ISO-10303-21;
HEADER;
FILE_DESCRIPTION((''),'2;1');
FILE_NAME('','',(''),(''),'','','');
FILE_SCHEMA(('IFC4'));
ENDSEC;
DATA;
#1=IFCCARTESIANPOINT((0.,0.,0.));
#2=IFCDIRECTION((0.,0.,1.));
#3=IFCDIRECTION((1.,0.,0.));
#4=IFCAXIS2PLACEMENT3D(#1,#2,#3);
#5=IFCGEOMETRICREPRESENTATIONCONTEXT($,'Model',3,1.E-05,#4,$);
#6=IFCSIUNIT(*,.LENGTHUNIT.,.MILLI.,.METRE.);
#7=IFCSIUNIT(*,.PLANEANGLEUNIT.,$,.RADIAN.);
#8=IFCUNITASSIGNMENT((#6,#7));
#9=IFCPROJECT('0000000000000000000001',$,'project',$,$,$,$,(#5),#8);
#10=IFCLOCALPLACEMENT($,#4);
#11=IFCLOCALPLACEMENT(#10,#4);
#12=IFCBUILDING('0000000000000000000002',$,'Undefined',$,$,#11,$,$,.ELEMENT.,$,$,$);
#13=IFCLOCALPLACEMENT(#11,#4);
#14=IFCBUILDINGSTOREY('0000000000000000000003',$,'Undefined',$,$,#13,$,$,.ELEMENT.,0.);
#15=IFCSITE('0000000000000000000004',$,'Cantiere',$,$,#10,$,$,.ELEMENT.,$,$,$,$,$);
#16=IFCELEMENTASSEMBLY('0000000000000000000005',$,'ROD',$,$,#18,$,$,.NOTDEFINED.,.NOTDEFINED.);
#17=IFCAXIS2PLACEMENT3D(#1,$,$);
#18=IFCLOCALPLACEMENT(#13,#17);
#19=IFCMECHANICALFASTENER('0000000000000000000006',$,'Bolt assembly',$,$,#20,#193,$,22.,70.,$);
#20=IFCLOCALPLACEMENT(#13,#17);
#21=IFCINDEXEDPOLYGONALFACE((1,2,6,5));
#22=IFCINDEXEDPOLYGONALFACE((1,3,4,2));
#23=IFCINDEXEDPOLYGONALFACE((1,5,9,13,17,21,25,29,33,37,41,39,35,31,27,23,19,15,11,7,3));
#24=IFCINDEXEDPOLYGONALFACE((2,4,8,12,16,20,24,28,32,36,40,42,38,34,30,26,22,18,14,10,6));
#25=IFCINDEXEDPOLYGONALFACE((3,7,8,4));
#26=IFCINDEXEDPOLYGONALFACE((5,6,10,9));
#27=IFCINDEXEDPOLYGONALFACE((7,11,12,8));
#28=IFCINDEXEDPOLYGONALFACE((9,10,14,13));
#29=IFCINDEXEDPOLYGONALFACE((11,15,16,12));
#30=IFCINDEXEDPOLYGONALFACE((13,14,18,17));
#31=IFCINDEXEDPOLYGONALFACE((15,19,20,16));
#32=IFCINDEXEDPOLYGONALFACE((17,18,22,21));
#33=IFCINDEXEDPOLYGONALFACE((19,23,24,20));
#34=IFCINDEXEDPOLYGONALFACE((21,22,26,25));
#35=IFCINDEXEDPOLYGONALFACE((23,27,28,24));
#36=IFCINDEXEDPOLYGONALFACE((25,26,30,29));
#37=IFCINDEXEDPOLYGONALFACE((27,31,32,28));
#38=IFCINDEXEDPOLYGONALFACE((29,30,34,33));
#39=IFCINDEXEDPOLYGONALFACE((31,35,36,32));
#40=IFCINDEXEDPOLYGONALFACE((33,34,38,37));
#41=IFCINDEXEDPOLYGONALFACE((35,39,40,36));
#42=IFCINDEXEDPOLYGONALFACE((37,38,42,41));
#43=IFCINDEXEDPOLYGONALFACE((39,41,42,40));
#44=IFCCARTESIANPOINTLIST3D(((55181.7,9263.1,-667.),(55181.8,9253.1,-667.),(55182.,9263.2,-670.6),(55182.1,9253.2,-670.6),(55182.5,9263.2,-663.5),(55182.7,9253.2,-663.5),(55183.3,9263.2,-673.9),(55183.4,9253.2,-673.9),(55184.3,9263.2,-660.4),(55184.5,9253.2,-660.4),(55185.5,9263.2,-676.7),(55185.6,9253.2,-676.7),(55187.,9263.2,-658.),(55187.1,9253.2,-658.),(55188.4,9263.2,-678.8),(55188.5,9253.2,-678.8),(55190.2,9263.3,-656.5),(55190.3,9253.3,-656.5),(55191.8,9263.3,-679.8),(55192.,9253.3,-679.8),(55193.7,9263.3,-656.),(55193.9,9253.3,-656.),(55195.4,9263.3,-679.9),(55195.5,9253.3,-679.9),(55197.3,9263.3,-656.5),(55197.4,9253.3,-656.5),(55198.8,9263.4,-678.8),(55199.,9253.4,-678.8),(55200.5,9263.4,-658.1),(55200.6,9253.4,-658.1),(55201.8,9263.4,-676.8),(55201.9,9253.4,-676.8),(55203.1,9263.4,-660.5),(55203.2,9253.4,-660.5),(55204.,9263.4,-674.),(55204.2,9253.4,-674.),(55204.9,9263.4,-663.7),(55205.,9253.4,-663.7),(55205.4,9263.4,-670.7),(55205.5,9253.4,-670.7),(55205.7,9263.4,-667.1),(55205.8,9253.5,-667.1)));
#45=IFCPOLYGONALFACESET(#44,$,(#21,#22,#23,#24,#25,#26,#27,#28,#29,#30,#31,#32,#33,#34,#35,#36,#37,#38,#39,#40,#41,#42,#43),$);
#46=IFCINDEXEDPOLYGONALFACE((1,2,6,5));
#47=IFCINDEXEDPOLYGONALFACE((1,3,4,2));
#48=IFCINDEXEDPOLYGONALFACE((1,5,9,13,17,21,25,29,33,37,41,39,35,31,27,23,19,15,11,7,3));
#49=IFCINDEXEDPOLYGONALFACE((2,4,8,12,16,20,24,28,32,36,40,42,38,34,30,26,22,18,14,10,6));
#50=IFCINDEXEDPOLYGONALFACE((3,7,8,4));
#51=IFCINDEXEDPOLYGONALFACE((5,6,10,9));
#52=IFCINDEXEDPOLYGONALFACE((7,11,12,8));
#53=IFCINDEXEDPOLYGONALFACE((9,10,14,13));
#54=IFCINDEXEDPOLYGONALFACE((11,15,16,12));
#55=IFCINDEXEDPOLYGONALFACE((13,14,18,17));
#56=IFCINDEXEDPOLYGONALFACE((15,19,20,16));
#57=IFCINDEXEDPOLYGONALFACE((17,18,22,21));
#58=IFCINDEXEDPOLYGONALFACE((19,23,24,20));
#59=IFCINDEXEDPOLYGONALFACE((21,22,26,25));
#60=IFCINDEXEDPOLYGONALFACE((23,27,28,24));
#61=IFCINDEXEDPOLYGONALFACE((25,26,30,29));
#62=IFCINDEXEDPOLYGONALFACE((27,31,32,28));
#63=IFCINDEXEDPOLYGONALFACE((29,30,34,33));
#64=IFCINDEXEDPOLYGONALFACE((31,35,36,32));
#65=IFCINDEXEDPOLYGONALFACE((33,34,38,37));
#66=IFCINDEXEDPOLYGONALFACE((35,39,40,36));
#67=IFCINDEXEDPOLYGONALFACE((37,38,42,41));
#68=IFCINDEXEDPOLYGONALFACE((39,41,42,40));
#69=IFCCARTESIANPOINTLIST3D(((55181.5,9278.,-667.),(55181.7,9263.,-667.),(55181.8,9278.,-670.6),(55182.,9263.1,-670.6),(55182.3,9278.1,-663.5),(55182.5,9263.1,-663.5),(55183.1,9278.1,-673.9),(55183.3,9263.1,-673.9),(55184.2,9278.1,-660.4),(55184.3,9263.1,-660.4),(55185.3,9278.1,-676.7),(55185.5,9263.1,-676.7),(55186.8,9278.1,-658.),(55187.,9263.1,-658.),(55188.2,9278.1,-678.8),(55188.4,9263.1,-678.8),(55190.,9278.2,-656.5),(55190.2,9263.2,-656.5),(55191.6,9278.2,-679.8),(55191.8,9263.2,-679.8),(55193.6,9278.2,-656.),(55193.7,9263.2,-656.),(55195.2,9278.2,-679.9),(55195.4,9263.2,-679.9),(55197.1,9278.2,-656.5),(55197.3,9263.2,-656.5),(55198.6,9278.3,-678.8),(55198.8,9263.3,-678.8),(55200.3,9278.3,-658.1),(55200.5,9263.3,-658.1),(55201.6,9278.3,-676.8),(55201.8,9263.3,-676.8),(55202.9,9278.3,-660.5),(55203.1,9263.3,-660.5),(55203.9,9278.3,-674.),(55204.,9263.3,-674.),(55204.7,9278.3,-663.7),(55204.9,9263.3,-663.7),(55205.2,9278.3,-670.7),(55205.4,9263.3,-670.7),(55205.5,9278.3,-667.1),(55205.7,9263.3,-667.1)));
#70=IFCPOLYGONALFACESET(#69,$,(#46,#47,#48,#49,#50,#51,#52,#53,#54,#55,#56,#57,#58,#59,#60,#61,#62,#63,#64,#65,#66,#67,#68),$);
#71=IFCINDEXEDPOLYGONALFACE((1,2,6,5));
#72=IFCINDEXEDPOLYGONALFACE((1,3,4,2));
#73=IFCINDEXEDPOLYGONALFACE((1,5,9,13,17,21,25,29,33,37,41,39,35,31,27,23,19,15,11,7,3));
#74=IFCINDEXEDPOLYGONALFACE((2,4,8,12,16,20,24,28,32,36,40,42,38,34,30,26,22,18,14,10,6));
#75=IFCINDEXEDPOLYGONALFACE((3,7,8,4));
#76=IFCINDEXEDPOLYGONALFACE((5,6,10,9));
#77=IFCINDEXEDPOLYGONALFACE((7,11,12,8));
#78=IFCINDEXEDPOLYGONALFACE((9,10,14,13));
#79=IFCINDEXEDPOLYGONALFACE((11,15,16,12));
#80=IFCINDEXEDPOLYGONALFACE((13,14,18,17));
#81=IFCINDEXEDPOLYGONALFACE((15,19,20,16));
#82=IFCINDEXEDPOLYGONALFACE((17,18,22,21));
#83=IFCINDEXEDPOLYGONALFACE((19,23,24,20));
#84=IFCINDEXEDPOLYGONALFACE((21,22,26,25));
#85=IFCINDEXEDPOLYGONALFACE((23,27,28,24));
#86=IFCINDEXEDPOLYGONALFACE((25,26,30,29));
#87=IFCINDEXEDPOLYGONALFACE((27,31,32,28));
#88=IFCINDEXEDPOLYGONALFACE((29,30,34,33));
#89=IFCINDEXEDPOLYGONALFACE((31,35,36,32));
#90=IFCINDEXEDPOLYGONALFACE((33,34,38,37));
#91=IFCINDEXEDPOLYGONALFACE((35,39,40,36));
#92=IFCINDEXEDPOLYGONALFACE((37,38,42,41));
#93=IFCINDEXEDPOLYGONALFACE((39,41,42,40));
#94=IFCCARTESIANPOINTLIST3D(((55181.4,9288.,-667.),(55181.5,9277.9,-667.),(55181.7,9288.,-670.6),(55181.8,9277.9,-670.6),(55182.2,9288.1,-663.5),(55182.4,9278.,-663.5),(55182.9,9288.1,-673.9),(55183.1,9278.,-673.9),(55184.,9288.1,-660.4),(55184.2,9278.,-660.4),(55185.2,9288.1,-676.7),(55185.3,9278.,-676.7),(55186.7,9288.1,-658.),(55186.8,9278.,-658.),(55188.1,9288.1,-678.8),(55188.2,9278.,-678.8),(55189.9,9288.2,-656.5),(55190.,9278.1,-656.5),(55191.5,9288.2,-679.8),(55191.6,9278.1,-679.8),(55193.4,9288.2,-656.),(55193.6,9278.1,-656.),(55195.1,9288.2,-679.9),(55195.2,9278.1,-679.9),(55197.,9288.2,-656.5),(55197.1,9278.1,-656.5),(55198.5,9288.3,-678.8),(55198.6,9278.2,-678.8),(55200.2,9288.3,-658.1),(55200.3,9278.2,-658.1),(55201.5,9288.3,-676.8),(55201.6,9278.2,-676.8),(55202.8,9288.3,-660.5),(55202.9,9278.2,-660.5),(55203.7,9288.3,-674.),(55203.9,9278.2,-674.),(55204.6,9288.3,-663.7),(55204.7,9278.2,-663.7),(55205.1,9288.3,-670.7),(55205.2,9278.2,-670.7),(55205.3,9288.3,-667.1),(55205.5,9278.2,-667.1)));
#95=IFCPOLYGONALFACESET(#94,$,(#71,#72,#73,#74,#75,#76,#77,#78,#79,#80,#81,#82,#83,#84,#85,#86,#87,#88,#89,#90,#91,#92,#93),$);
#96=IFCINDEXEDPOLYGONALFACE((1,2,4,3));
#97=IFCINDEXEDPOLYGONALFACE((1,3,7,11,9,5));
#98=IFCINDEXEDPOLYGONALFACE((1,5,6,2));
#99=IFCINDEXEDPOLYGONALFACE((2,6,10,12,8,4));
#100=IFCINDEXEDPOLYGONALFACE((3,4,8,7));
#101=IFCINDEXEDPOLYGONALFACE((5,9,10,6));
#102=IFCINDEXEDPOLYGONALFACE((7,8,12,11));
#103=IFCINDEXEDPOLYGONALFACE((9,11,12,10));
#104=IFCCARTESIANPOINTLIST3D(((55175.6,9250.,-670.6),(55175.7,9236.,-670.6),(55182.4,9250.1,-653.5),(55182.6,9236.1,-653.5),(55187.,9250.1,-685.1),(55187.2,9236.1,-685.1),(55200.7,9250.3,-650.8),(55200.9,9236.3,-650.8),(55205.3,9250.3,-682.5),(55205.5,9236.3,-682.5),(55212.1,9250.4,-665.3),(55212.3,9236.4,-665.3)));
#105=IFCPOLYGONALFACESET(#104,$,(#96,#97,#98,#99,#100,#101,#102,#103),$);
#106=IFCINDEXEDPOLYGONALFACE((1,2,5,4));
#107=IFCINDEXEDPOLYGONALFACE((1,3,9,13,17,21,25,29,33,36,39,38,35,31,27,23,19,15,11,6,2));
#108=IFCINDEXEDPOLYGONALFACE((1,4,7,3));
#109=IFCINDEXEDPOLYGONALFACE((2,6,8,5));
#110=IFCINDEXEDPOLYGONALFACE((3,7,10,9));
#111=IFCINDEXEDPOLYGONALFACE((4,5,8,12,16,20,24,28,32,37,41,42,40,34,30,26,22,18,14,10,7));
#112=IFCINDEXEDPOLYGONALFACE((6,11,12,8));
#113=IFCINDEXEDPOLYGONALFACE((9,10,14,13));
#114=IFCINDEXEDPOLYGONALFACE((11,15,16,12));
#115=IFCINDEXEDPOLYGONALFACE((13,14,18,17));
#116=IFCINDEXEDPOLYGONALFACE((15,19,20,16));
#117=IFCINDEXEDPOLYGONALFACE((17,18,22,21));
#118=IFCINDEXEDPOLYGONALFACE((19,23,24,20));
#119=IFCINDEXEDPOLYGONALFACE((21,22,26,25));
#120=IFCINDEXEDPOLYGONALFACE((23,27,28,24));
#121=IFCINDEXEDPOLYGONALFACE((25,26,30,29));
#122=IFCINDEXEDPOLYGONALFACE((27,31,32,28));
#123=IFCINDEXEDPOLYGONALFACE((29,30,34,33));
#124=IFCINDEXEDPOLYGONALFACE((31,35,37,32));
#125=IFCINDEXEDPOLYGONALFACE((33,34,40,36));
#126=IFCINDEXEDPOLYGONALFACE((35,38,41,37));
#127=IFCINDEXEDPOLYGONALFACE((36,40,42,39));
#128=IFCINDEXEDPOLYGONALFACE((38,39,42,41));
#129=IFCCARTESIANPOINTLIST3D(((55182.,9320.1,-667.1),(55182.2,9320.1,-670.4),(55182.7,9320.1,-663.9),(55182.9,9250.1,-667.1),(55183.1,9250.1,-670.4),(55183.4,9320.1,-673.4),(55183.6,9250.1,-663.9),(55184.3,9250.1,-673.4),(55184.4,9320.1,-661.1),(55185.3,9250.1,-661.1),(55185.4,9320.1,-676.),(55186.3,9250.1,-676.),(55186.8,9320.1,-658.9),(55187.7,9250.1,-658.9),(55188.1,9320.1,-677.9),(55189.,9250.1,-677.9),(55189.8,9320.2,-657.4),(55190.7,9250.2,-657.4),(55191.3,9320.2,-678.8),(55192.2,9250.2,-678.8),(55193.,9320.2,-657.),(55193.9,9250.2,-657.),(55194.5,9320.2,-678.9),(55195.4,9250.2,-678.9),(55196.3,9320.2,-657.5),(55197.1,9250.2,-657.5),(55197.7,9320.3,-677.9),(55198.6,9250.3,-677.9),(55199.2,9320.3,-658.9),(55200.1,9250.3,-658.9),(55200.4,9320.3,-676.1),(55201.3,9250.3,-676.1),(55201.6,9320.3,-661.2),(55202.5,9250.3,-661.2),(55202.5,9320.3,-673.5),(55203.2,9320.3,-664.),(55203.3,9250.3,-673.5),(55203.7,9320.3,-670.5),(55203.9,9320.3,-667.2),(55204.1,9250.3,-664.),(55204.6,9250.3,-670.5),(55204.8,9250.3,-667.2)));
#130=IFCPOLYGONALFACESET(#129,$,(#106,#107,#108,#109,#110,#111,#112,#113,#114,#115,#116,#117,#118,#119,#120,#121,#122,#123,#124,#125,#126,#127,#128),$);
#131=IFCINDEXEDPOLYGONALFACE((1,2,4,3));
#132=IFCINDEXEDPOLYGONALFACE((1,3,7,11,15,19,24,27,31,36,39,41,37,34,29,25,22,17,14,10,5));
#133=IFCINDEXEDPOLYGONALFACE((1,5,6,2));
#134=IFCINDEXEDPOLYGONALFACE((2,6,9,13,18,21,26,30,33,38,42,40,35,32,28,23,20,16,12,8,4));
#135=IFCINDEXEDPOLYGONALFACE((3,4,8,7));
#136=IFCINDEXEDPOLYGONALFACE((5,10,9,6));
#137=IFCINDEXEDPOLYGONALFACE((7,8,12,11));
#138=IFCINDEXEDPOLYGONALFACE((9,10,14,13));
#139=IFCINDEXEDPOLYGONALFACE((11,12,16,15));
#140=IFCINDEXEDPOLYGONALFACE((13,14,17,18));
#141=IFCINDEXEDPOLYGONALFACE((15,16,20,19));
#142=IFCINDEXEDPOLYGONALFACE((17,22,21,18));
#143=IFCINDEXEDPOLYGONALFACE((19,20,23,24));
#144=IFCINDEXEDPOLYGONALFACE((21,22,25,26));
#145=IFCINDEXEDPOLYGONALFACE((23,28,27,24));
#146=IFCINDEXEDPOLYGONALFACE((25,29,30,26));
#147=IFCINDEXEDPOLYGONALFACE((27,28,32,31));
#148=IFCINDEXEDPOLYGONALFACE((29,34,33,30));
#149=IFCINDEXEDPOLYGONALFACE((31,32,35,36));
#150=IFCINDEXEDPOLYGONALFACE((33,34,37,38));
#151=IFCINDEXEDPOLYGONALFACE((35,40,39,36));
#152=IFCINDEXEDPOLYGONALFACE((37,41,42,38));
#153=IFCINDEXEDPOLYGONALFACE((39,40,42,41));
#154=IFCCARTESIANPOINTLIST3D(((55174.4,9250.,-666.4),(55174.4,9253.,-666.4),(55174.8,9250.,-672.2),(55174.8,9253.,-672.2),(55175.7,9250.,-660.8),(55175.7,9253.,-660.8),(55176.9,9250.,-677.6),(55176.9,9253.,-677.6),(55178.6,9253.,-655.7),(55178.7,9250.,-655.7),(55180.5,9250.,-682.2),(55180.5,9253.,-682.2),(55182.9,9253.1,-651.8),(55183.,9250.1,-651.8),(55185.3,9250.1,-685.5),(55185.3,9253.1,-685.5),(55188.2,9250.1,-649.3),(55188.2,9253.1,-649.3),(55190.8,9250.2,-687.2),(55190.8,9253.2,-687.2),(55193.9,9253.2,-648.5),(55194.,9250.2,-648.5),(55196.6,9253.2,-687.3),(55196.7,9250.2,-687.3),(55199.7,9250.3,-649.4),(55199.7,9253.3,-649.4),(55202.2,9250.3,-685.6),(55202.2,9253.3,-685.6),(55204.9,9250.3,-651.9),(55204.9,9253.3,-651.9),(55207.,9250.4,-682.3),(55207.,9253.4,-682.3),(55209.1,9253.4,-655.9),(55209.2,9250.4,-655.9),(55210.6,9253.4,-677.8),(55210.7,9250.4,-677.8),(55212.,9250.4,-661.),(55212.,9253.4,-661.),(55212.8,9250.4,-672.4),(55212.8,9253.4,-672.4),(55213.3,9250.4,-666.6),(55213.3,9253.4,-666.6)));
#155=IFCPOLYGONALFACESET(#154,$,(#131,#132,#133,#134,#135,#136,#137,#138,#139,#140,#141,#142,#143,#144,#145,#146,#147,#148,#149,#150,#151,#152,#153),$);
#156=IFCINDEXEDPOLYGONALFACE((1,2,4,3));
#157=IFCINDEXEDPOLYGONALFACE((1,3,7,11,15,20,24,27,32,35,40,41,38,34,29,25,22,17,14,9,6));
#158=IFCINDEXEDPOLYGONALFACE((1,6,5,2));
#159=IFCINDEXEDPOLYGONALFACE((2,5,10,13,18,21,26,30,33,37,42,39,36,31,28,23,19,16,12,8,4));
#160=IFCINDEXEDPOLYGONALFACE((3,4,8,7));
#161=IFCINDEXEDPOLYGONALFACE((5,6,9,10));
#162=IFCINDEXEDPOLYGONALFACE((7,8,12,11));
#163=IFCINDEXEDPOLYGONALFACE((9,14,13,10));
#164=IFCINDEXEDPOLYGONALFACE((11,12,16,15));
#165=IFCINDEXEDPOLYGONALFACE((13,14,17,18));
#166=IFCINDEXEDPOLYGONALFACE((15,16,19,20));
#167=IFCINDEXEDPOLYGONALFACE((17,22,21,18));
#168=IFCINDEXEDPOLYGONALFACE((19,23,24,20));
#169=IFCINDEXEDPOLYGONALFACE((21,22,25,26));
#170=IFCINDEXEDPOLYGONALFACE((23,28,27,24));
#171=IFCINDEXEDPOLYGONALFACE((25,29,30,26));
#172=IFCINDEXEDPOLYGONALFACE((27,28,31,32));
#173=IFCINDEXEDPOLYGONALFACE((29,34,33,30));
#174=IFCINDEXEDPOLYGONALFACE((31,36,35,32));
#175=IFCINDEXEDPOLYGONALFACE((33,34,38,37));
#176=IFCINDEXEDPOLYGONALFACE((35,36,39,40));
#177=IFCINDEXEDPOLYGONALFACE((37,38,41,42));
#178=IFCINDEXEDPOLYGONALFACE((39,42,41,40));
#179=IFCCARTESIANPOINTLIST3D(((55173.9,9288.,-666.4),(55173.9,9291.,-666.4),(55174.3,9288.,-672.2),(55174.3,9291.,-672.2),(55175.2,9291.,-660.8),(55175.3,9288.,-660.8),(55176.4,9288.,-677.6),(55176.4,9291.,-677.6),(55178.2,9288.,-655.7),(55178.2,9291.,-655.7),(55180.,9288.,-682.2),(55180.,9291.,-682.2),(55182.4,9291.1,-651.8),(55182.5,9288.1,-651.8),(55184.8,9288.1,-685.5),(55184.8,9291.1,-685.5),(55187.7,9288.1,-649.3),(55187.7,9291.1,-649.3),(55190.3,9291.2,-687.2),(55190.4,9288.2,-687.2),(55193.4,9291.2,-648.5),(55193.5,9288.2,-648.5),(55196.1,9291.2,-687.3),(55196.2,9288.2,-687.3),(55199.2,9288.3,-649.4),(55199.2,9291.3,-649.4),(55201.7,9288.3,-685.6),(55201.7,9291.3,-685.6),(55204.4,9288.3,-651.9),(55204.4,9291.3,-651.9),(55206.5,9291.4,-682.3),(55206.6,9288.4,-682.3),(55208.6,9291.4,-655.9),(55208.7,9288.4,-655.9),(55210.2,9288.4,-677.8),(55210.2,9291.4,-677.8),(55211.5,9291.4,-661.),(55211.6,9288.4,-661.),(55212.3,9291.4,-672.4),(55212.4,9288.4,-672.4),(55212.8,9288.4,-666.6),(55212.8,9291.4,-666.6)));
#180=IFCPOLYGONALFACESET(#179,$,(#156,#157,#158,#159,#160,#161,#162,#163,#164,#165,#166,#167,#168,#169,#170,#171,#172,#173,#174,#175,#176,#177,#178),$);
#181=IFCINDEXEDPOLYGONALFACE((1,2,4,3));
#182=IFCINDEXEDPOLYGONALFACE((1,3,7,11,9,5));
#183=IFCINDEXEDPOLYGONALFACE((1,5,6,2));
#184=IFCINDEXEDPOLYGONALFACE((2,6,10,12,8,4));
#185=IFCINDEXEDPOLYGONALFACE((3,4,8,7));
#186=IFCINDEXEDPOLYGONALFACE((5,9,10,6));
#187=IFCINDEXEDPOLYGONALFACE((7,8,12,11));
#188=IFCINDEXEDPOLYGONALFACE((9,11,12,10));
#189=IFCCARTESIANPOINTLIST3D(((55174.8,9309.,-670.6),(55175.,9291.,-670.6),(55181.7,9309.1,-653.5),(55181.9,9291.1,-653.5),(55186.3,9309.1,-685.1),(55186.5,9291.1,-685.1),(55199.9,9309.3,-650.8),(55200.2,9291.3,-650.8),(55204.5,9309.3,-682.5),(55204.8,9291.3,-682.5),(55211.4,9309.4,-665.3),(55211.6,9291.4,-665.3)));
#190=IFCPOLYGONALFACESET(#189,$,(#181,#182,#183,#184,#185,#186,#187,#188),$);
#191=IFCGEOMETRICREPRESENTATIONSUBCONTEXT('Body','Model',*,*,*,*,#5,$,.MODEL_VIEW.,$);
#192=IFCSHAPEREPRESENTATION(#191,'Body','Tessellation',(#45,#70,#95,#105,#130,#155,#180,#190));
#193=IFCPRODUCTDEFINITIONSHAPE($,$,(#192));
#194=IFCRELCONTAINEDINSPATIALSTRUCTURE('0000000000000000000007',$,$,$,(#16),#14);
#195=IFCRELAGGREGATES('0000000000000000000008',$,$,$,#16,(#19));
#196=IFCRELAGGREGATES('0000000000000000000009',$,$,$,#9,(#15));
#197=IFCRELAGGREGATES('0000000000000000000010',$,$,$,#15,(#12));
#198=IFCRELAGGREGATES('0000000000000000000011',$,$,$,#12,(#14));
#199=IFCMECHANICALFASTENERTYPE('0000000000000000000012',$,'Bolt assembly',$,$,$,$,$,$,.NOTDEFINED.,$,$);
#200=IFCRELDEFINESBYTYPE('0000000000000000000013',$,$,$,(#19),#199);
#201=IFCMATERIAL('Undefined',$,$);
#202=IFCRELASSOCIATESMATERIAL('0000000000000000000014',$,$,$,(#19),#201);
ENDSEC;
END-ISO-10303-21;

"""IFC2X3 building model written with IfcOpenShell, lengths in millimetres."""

from ifc_helpers import new_model, si_unit, frame, origin_with_axes, origin_2d_with_axis, place, context, subcontext, project, spatial, polyline, circle, outline, extrude, source, transform, mapped, material, type_object, element, aggregate, save


model = new_model("IFC2X3")

# Units and contexts
model_context = context("Model", 3, precision=1e-05, world=origin_with_axes())
body_context = subcontext(model_context, "Body", "Model", "MODEL_VIEW")
ifc_project = project(units=[si_unit("LENGTHUNIT", "METRE", prefix="MILLI"), si_unit("PLANEANGLEUNIT", "RADIAN")], contexts=[model_context])

# Site, building, storey
site_placement = place(None, origin_with_axes())
site = spatial("IfcSite", under=ifc_project, at=site_placement, Name="Cantiere", CompositionType="ELEMENT")
building_placement = place(site_placement, origin_with_axes())
building = spatial("IfcBuilding", under=site, at=building_placement, Name="Undefined", CompositionType="ELEMENT")
storey_placement = place(building_placement, origin_with_axes())
storey = spatial("IfcBuildingStorey", under=building, at=storey_placement, Name="Undefined", CompositionType="ELEMENT", Elevation=0.0)

# Element assembly
assembly_1_placement = place(storey_placement, origin_with_axes())
assembly_1 = element("IfcElementAssembly", 1, at=assembly_1_placement, inside=storey, Name="ROD", AssemblyPlace="NOTDEFINED", PredefinedType="NOTDEFINED")

# Mechanical fastener
ifc_material_1 = material(Name="Undefined")
mechanical_fastener_type = type_object("IfcMechanicalFastenerType", Name="Bolt assembly")
shared_shape_1 = source(origin_with_axes(), body_context, "Body", "SweptSolid", [
    extrude(circle(Radius=12.0, at=origin_2d_with_axis()), frame((0.0, 0.1, 0.0), z_axis=(0.0, 1.0, 0.0), x_axis=(1.0, 0.0, 0.0)), (0.0, 0.0, 1.0), 10.0),
    extrude(circle(Radius=12.0, at=origin_2d_with_axis()), frame((0.0, 10.0, 0.0), z_axis=(0.0, 1.0, 0.0), x_axis=(1.0, 0.0, 0.0)), (0.0, 0.0, 1.0), 15.0),
    extrude(circle(Radius=12.0, at=origin_2d_with_axis()), frame((0.0, 24.9, 0.0), z_axis=(0.0, 1.0, 0.0), x_axis=(1.0, 0.0, 0.0)), (0.0, 0.0, 1.0), 10.1),
    extrude(outline(polyline([(16.0, -9.2), (16.0, 9.2), (0.0, 18.5), (-16.0, 9.2), (-16.0, -9.2), (0.0, -18.5), (16.0, -9.2)])), frame((0.0, -17.0, 0.0), z_axis=(0.0, 1.0, 0.0), x_axis=(1.0, 0.0, 0.0)), (0.0, 0.0, 1.0), 14.0),
    extrude(circle(Radius=11.0, at=origin_2d_with_axis()), frame((0.0, -3.0, 0.0), z_axis=(0.0, 1.0, 0.0), x_axis=(1.0, 0.0, 0.0)), (0.0, 0.0, 1.0), 70.0),
    extrude(circle(Radius=19.5, at=origin_2d_with_axis()), frame((0.0, -3.0, 0.0), z_axis=(0.0, 1.0, 0.0), x_axis=(1.0, 0.0, 0.0)), (0.0, 0.0, 1.0), 3.0),
    extrude(circle(Radius=19.5, at=origin_2d_with_axis()), frame((0.0, 35.0, 0.0), z_axis=(0.0, 1.0, 0.0), x_axis=(1.0, 0.0, 0.0)), (0.0, 0.0, 1.0), 3.0),
    extrude(outline(polyline([(16.0, -9.2), (16.0, 9.2), (0.0, 18.5), (-16.0, 9.2), (-16.0, -9.2), (0.0, -18.5), (16.0, -9.2)])), frame((0.0, 38.0, 0.0), z_axis=(0.0, 1.0, 0.0), x_axis=(1.0, 0.0, 0.0)), (0.0, 0.0, 1.0), 18.0),
])
mechanical_fastener_1_placement = place(assembly_1_placement, frame((55193.8, 9253.2, -668.0), z_axis=(-0.370312, -0.004673, -0.928896), x_axis=(-0.928822, -0.01172, 0.370341)))
mechanical_fastener_1 = element("IfcMechanicalFastener", 2, at=mechanical_fastener_1_placement, type_object=mechanical_fastener_type, material=ifc_material_1, Name="Bolt assembly", NominalDiameter=22.0, NominalLength=70.0, context=body_context, shape_type="MappedRepresentation", body=[
    mapped(shared_shape_1, transform((0.0, 0.0, 0.0))),
])
aggregate(assembly_1, [mechanical_fastener_1])

save(model, "model.ifc")
